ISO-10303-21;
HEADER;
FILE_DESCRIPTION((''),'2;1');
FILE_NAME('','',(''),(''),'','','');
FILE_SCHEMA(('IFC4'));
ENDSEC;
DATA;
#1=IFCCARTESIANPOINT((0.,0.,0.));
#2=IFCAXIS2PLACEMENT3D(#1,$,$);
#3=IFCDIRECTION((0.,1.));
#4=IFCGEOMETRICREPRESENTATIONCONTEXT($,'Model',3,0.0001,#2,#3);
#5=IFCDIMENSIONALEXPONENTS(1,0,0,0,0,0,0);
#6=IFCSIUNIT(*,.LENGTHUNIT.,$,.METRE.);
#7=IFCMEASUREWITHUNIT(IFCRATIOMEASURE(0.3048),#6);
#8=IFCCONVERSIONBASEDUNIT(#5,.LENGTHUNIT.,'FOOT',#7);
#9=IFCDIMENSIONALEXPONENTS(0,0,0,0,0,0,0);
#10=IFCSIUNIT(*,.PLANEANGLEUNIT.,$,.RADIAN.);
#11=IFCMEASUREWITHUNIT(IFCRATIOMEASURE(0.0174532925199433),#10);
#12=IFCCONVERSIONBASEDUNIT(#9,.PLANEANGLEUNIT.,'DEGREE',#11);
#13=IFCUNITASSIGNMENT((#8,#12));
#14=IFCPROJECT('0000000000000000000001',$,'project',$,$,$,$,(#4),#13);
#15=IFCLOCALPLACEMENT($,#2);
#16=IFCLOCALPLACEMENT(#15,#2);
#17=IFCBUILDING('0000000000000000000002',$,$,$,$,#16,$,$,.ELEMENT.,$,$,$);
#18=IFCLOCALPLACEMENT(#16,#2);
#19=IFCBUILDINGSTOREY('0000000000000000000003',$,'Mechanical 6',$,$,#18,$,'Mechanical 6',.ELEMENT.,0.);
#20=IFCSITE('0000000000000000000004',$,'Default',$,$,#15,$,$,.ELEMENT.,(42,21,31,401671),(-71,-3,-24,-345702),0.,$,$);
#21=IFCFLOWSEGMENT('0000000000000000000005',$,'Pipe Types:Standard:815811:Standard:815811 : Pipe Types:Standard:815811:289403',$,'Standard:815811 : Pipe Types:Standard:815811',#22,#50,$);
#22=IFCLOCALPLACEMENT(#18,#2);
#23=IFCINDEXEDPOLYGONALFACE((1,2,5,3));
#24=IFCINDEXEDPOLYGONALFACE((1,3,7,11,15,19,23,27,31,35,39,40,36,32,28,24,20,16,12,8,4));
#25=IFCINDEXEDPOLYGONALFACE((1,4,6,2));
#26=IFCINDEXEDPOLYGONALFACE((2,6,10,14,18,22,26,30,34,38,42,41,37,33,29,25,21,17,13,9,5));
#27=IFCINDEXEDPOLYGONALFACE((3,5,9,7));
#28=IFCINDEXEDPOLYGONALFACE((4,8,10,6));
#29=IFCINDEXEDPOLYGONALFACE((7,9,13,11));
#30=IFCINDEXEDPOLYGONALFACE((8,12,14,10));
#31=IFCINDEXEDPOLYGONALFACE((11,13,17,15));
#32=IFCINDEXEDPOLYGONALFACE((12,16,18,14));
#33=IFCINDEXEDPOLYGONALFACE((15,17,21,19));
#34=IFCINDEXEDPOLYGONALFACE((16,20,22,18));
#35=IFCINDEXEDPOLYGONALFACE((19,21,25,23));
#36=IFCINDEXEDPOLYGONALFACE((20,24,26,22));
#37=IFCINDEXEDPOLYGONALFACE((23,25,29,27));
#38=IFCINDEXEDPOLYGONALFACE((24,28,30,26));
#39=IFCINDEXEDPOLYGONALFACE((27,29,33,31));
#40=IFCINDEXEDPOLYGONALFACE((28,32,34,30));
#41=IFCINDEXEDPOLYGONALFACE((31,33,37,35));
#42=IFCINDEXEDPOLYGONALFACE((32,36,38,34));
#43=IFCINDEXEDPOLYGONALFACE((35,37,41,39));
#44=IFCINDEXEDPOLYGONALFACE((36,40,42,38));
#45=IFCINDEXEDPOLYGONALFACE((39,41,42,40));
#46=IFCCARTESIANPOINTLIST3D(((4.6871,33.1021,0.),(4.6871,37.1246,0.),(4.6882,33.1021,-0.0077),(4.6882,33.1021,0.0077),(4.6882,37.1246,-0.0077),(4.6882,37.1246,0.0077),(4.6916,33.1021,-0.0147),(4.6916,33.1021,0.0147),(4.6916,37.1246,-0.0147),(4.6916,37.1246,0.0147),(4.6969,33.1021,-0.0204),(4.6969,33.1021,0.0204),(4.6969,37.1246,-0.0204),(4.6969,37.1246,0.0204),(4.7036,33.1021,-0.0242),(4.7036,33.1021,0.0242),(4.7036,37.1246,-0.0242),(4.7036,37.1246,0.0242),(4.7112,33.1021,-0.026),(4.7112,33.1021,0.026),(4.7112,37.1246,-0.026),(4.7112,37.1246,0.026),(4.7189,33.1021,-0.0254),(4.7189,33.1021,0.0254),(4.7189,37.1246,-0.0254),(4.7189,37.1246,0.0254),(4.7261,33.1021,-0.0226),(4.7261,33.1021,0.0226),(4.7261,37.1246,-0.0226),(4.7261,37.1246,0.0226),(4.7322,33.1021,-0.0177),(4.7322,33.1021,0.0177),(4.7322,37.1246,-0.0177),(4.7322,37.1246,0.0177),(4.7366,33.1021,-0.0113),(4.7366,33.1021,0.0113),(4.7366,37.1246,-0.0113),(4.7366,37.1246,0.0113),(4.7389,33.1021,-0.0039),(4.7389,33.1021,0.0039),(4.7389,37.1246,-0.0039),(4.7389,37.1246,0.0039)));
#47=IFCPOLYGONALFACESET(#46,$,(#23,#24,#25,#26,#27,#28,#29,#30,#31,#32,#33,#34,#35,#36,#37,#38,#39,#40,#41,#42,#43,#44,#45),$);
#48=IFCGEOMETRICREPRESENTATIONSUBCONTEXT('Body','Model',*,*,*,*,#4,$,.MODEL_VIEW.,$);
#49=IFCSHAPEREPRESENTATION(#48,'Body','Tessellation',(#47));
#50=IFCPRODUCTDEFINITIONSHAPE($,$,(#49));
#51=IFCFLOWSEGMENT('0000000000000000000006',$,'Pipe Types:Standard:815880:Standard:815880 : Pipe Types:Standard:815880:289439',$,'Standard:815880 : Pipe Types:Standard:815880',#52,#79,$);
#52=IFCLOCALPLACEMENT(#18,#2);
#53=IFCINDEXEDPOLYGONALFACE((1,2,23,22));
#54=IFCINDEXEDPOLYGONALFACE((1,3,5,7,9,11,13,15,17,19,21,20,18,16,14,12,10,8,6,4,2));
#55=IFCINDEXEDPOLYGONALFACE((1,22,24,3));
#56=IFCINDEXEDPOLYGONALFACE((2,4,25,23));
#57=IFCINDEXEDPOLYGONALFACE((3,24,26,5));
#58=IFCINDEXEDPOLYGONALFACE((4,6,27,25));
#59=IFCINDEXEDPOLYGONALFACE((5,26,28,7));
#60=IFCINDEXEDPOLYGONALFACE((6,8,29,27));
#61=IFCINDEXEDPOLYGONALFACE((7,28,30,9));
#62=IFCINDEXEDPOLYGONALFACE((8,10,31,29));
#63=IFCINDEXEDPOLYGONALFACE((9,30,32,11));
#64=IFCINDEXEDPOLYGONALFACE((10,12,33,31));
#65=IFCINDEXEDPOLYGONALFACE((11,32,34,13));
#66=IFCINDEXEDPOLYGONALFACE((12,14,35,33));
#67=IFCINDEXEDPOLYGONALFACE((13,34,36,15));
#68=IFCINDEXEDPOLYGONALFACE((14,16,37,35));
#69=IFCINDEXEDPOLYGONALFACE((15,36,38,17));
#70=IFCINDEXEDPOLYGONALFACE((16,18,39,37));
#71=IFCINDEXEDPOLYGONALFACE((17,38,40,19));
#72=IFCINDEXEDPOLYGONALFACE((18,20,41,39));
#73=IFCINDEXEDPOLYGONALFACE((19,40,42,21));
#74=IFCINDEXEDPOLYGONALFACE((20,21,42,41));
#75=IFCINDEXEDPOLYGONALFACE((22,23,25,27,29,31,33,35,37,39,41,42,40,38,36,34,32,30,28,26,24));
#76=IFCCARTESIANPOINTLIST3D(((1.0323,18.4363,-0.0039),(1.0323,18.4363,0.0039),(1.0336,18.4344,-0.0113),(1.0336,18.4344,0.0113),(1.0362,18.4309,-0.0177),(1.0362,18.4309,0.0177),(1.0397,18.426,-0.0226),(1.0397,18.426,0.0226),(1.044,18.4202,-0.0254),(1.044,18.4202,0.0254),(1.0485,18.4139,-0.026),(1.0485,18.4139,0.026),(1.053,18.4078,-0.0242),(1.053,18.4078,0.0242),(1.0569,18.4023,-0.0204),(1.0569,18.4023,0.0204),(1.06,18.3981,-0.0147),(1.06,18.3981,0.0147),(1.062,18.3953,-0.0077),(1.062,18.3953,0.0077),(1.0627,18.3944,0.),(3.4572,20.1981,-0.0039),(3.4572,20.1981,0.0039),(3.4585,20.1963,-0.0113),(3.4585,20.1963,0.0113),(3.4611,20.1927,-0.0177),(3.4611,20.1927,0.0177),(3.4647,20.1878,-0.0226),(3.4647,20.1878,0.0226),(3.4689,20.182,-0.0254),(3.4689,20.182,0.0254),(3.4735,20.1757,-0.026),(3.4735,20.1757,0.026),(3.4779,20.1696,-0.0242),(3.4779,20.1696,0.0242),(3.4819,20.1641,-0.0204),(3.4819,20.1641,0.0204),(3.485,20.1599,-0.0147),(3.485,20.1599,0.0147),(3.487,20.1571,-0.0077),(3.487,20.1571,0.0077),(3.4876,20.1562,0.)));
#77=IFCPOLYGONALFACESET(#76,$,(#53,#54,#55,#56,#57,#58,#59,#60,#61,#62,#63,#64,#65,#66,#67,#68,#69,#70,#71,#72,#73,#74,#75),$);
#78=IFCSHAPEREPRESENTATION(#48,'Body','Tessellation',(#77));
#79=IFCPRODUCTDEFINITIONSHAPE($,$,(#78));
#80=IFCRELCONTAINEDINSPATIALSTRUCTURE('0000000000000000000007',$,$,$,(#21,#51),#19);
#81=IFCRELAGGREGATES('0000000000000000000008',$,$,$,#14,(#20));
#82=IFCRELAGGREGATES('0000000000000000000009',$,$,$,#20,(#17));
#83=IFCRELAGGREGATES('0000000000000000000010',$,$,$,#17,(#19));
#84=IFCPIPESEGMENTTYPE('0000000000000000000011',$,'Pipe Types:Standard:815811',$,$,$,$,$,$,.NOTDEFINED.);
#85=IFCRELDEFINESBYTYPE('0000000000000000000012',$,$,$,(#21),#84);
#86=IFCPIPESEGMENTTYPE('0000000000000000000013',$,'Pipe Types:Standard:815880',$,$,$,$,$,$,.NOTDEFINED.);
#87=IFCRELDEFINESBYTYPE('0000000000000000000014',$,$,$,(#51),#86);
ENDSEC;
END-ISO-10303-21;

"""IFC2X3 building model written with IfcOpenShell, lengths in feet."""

from ifc_helpers import new_model, entity, si_unit, converted_unit, direction, frame, frame_2d, origin, place, context, subcontext, project, spatial, circle, extrude, source, transform, mapped, type_object, type_shapes, element, save


model = new_model("IFC2X3")

# Units and contexts
model_context = context("Model", 3, precision=0.0001, world=origin(), true_north=direction((0.0, 1.0)))
body_context = subcontext(model_context, "Body", "Model", "MODEL_VIEW")
ifc_project = project(units=[converted_unit("LENGTHUNIT", "FOOT", entity("IfcRatioMeasure", 0.3048), si_unit("LENGTHUNIT", "METRE"), dimensions=[1, 0, 0, 0, 0, 0, 0]), converted_unit("PLANEANGLEUNIT", "DEGREE", entity("IfcRatioMeasure", 0.0174532925199433), si_unit("PLANEANGLEUNIT", "RADIAN"), dimensions=[0, 0, 0, 0, 0, 0, 0])], contexts=[model_context])

# Site, building, storey
site_placement = place(None, origin())
site = spatial("IfcSite", under=ifc_project, at=site_placement, Name="Default", CompositionType="ELEMENT", RefLatitude=(42, 21, 31, 401671), RefLongitude=(-71, -3, -24, -345702), RefElevation=0.0)
building_placement = place(site_placement, origin())
building = spatial("IfcBuilding", under=site, at=building_placement, CompositionType="ELEMENT")
storey_placement = place(building_placement, origin())
storey = spatial("IfcBuildingStorey", under=building, at=storey_placement, Name="Mechanical 6", LongName="Mechanical 6", CompositionType="ELEMENT", Elevation=0.0)

# Flow segments
pipe_segment_type_1 = type_object("IfcPipeSegmentType", Name="Pipe Types:Standard:815811", PredefinedType="NOTDEFINED")
shared_shape_1 = source(origin(), body_context, "Body", "SweptSolid", [
    extrude(circle(Radius=0.026, at=frame_2d((0.0, 0.0), x_axis=(1.0, 0.0))), frame((4.7131, 33.1021, 0.0), z_axis=(0.0, 1.0, 0.0), x_axis=(-1.0, 0.0, 0.0)), (0.0, 0.0, 1.0), 4.0225),
])
type_shapes(pipe_segment_type_1, [shared_shape_1])
flow_segment_1_placement = place(building_placement, origin())
element("IfcFlowSegment", 1, at=flow_segment_1_placement, inside=storey, type_object=pipe_segment_type_1, Name="Pipe Types:Standard:815811:Standard:815811 : Pipe Types:Standard:815811:289403", ObjectType="Standard:815811 : Pipe Types:Standard:815811", context=body_context, shape_type="MappedRepresentation", body=[
    mapped(shared_shape_1, transform((0.0, 0.0, 0.0), scale=1.0)),
])
pipe_segment_type_2 = type_object("IfcPipeSegmentType", Name="Pipe Types:Standard:815880", PredefinedType="NOTDEFINED")
shared_shape_2 = source(origin(), body_context, "Body", "SweptSolid", [
    extrude(circle(Radius=0.026, at=frame_2d((0.0, 0.0), x_axis=(1.0, 0.0))), frame((1.0474, 18.4155, 0.0), z_axis=(0.809017, 0.587785, 0.0), x_axis=(0.587785, -0.809017, 0.0)), (0.0, 0.0, 1.0), 2.9974),
])
type_shapes(pipe_segment_type_2, [shared_shape_2])
flow_segment_2_placement = place(building_placement, origin())
element("IfcFlowSegment", 2, at=flow_segment_2_placement, inside=storey, type_object=pipe_segment_type_2, Name="Pipe Types:Standard:815880:Standard:815880 : Pipe Types:Standard:815880:289439", ObjectType="Standard:815880 : Pipe Types:Standard:815880", context=body_context, shape_type="MappedRepresentation", body=[
    mapped(shared_shape_2, transform((0.0, 0.0, 0.0), scale=1.0)),
])

save(model, "model.ifc")
